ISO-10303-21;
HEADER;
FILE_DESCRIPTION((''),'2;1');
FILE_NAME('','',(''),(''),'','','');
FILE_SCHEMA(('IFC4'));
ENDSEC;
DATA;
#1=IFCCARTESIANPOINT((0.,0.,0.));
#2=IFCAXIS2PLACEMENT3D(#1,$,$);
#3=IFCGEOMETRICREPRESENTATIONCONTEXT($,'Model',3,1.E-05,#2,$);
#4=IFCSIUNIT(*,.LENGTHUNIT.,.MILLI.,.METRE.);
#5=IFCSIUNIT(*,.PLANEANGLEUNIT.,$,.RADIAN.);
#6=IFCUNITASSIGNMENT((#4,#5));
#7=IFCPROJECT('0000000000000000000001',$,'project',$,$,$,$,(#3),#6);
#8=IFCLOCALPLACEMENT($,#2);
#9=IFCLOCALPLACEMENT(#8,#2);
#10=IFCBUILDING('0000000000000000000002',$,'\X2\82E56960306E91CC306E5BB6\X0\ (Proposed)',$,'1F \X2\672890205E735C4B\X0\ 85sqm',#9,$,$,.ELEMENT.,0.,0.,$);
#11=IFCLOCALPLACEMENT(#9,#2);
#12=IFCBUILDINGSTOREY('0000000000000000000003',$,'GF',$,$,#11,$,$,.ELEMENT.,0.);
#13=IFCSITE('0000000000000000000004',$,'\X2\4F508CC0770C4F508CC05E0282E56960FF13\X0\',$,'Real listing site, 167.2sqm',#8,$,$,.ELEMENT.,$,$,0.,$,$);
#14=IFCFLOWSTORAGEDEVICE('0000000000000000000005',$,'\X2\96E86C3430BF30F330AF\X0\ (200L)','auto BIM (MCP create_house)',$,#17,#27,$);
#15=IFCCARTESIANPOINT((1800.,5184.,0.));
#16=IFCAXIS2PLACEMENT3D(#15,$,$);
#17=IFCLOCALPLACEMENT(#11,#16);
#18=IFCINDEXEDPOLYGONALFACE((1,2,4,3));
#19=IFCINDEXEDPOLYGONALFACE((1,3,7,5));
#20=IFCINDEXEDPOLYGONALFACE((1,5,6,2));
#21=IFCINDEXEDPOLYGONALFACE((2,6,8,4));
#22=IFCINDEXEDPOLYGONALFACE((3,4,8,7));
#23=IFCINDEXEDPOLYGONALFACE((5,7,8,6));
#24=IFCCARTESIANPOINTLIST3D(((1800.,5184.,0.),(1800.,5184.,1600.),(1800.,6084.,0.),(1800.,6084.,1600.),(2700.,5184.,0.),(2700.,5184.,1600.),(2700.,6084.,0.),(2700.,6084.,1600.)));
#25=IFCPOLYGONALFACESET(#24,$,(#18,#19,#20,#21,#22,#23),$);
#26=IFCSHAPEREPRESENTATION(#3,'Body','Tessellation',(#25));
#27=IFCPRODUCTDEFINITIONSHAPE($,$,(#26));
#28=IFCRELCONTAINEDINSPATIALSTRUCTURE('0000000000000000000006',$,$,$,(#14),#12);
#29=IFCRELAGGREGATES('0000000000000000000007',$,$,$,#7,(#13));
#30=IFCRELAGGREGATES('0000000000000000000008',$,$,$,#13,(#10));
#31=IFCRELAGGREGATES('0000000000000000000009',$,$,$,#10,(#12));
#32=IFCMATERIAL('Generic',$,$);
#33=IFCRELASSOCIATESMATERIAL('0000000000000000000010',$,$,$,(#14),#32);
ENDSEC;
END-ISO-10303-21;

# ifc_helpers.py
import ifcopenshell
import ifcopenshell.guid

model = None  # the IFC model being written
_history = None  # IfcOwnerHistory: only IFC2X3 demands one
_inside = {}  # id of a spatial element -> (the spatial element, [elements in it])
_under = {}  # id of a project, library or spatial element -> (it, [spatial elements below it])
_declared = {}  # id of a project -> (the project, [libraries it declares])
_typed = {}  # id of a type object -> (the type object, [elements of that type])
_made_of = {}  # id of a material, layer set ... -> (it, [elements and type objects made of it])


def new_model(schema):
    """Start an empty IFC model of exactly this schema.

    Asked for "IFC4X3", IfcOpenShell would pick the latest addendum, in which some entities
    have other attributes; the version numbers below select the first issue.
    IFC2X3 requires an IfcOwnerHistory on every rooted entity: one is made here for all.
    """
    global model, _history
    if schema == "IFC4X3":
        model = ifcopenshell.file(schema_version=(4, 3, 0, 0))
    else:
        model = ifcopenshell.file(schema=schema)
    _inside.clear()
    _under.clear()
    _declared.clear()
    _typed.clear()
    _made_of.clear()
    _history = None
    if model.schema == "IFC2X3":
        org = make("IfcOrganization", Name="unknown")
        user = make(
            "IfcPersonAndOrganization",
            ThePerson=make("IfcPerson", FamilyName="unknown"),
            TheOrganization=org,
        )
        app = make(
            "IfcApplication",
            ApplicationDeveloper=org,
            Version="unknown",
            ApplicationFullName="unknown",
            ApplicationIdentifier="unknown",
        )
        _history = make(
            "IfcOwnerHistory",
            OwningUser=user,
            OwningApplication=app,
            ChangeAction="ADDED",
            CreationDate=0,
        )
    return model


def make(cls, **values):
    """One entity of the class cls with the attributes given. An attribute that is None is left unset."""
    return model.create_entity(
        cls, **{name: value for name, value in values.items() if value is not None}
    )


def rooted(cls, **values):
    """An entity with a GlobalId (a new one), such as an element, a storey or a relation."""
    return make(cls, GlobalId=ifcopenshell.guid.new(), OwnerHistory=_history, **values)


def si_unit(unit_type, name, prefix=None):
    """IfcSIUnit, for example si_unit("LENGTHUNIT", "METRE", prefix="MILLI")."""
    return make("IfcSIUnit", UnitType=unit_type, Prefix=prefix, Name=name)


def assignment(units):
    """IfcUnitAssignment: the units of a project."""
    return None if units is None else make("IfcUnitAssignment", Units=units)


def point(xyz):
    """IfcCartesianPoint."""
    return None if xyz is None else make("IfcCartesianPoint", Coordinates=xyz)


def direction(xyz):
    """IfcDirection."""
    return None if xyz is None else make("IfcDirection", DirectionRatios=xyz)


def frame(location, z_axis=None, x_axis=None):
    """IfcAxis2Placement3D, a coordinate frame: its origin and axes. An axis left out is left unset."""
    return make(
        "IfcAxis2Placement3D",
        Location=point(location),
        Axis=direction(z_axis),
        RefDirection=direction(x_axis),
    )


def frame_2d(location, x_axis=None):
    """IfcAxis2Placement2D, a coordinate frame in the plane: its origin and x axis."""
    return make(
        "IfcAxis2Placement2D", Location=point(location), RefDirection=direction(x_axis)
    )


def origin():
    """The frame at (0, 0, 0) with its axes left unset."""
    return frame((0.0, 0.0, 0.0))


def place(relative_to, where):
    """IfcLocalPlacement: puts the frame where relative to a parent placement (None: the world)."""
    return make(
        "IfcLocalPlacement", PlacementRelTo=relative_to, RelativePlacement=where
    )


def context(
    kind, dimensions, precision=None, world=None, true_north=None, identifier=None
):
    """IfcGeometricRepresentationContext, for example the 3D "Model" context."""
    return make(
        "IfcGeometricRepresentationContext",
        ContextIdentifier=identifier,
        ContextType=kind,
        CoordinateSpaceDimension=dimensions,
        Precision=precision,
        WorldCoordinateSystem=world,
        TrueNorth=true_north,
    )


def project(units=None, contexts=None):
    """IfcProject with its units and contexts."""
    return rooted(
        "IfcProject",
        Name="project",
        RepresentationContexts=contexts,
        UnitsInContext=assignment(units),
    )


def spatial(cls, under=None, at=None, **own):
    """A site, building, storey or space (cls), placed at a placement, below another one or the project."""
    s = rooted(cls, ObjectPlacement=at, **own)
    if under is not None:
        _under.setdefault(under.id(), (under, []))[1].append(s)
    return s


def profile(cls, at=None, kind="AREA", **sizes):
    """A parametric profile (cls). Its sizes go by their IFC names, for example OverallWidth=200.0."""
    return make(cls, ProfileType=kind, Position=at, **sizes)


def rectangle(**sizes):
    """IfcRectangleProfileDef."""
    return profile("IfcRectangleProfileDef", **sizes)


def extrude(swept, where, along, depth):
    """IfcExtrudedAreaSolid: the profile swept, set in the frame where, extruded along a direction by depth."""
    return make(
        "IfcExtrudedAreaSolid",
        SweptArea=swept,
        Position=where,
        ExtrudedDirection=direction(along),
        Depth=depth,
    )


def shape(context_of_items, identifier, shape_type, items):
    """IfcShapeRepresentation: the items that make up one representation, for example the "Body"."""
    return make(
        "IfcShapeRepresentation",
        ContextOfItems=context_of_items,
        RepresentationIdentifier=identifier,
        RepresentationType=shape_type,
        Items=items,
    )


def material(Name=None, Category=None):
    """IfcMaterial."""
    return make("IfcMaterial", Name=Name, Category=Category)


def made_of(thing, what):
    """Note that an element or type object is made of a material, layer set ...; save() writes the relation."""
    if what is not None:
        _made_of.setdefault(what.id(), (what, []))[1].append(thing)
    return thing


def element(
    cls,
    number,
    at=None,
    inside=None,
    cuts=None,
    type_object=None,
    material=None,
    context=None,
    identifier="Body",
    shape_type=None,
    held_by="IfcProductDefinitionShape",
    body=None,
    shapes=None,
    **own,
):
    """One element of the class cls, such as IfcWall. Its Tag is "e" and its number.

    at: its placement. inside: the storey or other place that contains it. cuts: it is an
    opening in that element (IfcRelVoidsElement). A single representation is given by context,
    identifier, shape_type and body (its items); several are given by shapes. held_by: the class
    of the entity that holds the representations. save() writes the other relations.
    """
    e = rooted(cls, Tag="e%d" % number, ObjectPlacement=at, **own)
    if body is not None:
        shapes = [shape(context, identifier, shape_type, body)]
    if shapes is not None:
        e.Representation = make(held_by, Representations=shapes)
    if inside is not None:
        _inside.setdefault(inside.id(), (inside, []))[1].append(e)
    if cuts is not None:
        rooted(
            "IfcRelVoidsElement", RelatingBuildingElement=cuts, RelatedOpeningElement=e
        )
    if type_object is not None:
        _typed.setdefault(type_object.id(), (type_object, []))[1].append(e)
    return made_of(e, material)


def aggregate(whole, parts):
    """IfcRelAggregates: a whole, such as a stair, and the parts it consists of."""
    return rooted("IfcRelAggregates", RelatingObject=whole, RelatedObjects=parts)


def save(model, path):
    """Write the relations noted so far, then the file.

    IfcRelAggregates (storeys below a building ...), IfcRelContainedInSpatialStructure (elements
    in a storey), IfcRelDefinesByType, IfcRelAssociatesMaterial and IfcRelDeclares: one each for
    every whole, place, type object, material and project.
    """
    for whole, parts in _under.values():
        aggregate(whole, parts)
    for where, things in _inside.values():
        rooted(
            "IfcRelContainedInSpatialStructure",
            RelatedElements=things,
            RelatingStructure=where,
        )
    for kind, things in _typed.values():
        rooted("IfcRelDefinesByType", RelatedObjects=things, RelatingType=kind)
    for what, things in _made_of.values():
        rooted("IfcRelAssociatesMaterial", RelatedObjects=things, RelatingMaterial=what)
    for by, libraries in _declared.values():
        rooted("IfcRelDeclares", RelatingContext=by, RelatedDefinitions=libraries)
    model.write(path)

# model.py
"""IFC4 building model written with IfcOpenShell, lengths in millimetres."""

from ifc_helpers import new_model, si_unit, frame, frame_2d, origin, place, context, project, spatial, rectangle, extrude, material, element, save


model = new_model("IFC4")

# Units and contexts
model_context = context("Model", 3, precision=1e-05, world=origin())
ifc_project = project(units=[si_unit("LENGTHUNIT", "METRE", prefix="MILLI"), si_unit("PLANEANGLEUNIT", "RADIAN")], contexts=[model_context])

# Site, building, storey
site_placement = place(None, origin())
site = spatial("IfcSite", under=ifc_project, at=site_placement, Name="佐賀県佐賀市若楠３", ObjectType="Real listing site, 167.2sqm", CompositionType="ELEMENT", RefElevation=0.0)
building_placement = place(site_placement, origin())
building = spatial("IfcBuilding", under=site, at=building_placement, Name="若楠の里の家 (Proposed)", ObjectType="1F 木造平屋 85sqm", CompositionType="ELEMENT", ElevationOfRefHeight=0.0, ElevationOfTerrain=0.0)
storey_placement = place(building_placement, origin())
storey = spatial("IfcBuildingStorey", under=building, at=storey_placement, Name="GF", CompositionType="ELEMENT", Elevation=0.0)

# Shared definitions
ifc_material_1 = material(Name="Generic")

# Flow storage device
flow_storage_device_placement = place(storey_placement, frame((1800.0, 5184.0, 0.0)))
element("IfcFlowStorageDevice", 1, at=flow_storage_device_placement, inside=storey, material=ifc_material_1, Name="雨水タンク (200L)", Description="auto BIM (MCP create_house)", context=model_context, shape_type="SweptSolid", body=[
    extrude(rectangle(XDim=900.0, YDim=900.0, at=frame_2d((450.0, 450.0))), frame((1800.0, 5184.0, 0.0)), (0.0, 0.0, 1.0), 1600.0),
])

save(model, "model.ifc")
